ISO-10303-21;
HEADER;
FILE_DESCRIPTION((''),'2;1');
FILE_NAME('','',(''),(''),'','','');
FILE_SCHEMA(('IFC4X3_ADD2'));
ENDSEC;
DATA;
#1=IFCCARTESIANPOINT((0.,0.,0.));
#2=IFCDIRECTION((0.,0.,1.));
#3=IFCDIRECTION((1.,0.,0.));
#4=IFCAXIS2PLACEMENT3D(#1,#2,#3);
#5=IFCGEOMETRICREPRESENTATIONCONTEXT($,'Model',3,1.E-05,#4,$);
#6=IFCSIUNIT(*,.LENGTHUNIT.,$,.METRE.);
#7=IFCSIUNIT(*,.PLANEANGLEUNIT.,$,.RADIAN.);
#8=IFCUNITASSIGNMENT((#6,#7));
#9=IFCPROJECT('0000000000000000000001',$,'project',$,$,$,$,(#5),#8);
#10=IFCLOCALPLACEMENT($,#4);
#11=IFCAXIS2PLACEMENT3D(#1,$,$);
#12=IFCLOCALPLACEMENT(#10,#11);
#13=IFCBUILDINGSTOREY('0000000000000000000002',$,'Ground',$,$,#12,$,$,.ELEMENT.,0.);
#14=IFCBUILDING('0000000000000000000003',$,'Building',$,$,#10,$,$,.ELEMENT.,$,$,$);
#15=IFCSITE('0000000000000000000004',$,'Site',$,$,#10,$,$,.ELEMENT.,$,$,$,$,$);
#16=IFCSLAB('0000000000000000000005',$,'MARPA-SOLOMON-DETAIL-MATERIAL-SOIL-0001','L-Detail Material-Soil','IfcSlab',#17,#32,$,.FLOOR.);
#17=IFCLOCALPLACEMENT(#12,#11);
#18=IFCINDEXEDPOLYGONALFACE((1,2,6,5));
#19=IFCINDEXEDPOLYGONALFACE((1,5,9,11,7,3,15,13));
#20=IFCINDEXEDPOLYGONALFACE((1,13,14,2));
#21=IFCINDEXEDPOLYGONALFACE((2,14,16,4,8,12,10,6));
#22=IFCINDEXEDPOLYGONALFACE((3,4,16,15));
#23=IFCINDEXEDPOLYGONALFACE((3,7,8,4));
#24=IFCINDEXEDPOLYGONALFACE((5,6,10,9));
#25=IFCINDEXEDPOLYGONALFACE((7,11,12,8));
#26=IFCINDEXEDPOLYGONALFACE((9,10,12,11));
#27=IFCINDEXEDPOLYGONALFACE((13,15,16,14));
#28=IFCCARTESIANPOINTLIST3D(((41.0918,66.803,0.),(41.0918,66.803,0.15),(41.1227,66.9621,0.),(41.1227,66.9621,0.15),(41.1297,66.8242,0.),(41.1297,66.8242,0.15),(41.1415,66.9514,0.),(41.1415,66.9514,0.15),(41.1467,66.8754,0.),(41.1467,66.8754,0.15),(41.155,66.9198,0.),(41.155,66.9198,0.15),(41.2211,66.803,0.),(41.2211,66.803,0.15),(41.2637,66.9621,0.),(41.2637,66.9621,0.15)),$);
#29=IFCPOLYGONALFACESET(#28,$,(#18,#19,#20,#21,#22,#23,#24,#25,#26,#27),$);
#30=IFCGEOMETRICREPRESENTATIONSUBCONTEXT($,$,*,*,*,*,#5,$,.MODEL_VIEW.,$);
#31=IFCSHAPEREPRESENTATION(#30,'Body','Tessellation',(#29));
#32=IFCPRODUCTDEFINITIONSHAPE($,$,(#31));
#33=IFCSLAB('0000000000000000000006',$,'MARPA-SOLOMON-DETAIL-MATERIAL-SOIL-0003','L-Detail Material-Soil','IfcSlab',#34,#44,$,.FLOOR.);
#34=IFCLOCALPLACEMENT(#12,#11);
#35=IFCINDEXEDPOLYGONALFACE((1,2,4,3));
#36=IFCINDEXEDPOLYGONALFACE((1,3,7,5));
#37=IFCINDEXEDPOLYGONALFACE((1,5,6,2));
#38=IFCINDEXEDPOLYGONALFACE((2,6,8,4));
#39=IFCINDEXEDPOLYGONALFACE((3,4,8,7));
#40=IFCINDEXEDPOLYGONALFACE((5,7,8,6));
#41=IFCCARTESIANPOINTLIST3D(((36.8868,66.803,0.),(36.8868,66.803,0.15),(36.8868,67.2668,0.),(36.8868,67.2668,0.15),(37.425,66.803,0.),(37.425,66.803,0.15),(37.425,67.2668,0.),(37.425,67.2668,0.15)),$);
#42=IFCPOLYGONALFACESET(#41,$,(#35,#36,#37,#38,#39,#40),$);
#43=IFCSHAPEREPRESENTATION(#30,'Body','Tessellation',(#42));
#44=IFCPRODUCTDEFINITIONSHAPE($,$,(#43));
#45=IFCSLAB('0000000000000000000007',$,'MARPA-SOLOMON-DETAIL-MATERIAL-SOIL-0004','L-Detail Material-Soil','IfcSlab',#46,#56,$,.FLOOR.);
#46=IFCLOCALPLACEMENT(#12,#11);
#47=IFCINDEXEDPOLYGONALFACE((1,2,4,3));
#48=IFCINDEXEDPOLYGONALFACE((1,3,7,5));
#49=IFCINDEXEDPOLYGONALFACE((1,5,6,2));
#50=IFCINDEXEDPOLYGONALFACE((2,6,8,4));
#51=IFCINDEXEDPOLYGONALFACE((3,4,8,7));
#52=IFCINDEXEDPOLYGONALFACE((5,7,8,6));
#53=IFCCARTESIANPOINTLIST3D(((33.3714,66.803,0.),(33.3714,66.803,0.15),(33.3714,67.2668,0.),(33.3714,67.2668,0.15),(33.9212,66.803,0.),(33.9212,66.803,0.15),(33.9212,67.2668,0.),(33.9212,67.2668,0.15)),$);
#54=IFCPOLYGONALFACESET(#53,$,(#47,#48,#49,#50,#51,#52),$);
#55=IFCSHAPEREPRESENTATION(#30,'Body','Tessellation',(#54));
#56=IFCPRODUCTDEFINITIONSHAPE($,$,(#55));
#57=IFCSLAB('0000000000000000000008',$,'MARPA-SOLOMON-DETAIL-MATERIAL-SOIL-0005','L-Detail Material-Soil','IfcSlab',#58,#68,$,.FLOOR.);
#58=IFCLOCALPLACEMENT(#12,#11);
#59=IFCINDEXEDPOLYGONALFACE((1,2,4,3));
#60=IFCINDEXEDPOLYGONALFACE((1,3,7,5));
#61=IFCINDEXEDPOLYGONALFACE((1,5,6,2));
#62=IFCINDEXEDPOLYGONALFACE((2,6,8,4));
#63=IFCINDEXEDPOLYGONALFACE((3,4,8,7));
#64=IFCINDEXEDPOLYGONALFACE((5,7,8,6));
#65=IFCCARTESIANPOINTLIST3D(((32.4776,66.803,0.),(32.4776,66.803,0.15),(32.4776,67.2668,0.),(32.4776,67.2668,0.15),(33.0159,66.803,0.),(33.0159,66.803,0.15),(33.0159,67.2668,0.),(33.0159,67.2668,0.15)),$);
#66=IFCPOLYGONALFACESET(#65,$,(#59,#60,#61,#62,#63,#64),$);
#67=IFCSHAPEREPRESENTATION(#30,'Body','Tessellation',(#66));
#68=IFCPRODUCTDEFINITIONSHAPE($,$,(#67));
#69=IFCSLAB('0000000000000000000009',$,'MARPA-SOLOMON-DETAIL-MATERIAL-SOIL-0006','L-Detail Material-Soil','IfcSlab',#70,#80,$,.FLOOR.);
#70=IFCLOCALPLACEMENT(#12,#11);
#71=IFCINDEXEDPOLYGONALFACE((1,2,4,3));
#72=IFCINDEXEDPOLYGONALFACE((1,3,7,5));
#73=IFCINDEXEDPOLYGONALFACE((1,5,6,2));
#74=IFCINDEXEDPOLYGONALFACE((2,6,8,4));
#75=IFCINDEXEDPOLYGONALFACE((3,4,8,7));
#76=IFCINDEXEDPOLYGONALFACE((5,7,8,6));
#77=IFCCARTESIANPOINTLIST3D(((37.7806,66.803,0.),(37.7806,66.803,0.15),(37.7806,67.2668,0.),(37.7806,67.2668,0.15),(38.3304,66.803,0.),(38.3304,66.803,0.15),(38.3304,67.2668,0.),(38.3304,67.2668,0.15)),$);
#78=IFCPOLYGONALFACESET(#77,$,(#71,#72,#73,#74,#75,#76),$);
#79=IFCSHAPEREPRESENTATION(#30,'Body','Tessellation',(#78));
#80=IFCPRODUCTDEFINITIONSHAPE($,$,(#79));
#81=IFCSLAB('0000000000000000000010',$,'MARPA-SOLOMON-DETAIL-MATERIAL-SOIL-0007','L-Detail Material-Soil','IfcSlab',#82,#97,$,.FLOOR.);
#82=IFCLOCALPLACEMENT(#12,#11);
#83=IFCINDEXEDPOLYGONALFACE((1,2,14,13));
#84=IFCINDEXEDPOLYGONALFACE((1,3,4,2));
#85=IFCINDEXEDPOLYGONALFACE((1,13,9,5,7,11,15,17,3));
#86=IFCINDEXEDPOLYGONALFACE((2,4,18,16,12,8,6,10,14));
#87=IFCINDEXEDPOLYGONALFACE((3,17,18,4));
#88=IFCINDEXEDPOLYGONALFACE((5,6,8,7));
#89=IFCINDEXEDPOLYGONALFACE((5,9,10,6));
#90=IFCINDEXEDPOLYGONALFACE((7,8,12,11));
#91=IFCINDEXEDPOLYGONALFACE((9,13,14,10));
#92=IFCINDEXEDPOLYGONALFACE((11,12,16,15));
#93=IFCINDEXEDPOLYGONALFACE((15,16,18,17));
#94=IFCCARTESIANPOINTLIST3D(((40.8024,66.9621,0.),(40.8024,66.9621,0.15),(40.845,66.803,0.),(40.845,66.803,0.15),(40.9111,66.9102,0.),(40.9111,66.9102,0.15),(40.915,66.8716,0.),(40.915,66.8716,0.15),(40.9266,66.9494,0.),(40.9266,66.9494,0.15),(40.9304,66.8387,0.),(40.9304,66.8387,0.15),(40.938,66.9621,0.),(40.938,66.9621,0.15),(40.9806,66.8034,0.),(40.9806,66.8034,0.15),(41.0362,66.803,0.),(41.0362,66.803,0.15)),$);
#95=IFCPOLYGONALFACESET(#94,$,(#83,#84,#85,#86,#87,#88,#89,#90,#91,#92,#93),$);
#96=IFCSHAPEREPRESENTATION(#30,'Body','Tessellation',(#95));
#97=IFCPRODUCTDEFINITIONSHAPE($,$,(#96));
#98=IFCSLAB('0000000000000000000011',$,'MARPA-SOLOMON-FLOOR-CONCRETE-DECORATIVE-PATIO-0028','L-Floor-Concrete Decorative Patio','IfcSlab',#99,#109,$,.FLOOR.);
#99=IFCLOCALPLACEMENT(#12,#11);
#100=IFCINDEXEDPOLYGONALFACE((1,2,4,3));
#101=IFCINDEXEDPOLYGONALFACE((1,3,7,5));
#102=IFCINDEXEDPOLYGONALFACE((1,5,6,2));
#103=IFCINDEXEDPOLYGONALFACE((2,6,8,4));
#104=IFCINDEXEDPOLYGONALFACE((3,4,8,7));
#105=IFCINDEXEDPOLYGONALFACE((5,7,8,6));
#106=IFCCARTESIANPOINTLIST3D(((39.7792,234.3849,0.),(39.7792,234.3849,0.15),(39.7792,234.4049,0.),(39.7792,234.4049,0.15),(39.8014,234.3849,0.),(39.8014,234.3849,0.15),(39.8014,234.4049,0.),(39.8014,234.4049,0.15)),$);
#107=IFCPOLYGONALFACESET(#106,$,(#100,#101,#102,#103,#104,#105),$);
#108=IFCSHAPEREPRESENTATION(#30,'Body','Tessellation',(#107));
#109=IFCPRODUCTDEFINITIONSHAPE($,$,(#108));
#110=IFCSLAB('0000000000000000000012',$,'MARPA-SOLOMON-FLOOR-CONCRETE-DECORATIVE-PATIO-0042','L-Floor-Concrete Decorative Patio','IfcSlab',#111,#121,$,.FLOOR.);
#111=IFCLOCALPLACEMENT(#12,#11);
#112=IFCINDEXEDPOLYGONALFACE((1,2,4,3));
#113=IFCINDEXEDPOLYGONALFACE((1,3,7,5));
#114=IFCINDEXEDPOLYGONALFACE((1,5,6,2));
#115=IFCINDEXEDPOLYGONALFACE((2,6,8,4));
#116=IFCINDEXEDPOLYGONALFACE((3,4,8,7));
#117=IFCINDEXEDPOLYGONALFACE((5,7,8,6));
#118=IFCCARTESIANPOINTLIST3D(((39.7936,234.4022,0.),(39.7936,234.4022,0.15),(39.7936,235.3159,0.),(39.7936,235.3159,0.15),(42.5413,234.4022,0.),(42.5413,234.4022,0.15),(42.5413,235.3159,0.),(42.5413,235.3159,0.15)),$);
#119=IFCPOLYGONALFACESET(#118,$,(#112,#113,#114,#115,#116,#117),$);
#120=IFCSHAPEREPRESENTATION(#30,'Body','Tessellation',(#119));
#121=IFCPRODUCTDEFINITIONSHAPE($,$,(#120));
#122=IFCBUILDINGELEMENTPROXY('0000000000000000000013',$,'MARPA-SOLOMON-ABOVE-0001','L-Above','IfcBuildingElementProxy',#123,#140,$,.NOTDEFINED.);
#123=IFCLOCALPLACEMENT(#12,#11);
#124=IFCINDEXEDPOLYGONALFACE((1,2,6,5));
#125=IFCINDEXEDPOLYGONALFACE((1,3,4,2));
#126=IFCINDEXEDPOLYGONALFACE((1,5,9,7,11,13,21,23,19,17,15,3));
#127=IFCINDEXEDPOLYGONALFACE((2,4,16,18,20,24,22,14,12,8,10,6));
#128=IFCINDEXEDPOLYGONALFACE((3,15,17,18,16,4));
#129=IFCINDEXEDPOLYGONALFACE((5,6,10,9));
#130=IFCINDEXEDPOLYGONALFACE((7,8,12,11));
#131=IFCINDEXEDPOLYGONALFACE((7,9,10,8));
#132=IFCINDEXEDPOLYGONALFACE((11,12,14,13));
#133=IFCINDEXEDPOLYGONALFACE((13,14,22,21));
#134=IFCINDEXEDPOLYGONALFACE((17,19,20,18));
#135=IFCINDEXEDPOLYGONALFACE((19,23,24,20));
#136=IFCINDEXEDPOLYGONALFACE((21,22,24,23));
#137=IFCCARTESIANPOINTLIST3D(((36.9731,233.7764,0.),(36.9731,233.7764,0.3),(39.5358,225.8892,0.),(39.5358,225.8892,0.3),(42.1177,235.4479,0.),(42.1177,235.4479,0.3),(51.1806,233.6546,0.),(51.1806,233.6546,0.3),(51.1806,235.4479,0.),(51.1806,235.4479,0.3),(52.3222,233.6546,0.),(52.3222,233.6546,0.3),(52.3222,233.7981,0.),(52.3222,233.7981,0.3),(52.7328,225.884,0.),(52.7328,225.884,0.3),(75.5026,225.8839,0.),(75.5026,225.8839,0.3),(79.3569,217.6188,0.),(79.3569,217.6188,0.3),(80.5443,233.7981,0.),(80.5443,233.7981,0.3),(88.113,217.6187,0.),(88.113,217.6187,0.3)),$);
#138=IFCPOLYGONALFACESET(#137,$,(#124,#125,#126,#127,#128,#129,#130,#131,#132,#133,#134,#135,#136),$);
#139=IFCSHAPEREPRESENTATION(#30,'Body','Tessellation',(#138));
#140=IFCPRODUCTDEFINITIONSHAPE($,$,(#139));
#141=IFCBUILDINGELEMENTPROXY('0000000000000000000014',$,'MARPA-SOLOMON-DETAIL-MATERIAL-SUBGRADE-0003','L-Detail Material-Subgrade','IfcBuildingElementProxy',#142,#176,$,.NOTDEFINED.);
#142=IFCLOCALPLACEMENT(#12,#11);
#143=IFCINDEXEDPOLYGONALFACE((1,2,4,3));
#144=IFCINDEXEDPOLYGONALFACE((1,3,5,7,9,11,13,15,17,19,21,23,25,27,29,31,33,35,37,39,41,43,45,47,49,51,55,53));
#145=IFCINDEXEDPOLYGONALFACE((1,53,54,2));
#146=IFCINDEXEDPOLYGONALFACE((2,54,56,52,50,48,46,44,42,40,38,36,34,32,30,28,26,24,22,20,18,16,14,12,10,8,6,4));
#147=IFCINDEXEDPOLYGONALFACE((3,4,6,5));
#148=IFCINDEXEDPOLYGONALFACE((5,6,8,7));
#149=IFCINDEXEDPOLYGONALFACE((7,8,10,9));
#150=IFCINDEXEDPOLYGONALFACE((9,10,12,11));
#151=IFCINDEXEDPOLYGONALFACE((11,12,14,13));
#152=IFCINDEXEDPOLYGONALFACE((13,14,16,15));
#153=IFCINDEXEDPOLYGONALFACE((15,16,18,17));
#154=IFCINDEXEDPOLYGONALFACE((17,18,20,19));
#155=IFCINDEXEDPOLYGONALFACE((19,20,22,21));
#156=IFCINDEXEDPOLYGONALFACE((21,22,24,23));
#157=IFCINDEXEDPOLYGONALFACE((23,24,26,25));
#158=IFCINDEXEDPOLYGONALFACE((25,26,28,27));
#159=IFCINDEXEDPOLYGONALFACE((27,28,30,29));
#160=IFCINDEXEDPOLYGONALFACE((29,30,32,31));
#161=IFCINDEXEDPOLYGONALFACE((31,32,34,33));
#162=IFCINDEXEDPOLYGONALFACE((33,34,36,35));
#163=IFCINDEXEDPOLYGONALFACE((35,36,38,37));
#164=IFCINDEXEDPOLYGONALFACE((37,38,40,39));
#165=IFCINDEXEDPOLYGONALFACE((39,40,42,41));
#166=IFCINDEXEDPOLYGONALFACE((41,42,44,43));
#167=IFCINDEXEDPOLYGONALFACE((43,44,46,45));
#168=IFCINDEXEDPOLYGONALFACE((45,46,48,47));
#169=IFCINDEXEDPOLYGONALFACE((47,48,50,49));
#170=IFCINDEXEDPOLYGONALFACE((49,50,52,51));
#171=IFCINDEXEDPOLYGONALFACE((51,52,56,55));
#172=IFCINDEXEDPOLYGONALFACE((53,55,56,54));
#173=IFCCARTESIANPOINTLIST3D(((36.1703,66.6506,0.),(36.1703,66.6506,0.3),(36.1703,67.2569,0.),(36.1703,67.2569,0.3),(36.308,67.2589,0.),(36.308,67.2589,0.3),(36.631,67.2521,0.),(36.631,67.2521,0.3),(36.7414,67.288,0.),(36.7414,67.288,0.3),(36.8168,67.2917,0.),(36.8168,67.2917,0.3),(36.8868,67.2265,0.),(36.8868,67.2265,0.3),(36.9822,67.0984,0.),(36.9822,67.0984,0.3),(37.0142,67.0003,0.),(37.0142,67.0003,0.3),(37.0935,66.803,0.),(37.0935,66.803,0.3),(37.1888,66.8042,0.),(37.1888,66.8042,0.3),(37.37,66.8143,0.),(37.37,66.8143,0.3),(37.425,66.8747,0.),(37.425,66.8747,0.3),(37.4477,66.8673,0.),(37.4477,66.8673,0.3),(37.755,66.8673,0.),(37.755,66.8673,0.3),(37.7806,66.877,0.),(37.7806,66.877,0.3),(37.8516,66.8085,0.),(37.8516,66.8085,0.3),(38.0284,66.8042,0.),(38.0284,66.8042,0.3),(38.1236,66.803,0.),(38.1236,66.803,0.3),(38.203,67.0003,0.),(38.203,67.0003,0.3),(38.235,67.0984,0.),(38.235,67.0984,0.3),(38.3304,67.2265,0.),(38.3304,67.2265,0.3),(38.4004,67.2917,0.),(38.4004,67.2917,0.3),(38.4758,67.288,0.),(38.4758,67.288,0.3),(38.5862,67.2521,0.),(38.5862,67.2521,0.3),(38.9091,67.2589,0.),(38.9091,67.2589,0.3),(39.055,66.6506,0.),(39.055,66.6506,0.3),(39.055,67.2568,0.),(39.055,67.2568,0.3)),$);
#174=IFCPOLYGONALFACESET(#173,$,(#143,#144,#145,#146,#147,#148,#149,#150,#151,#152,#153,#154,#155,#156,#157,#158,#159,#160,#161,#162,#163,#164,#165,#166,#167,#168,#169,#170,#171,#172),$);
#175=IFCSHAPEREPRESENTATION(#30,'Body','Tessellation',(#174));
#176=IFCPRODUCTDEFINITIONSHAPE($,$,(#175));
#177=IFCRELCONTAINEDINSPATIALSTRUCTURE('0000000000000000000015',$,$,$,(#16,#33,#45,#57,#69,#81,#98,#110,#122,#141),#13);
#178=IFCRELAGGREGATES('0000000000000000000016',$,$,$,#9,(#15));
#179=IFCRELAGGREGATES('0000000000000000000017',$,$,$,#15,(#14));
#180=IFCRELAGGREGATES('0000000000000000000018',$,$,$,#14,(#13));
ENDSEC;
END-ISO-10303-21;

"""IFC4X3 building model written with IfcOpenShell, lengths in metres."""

from ifc_helpers import new_model, si_unit, frame, frame_2d, origin, origin_with_axes, place, context, subcontext, project, spatial, polyline, rectangle, outline, extrude, element, save


model = new_model("IFC4X3")

# Units and contexts
model_context = context("Model", 3, precision=1e-05, world=origin_with_axes())
sub_context = subcontext(model_context, None, None, "MODEL_VIEW")
ifc_project = project(units=[si_unit("LENGTHUNIT", "METRE"), si_unit("PLANEANGLEUNIT", "RADIAN")], contexts=[model_context])

# Site, building, storey
placement = place(None, origin_with_axes())
site = spatial("IfcSite", under=ifc_project, at=placement, Name="Site", CompositionType="ELEMENT")
building = spatial("IfcBuilding", under=site, at=placement, Name="Building", CompositionType="ELEMENT")
storey_placement = place(placement, origin())
storey = spatial("IfcBuildingStorey", under=building, at=storey_placement, Name="Ground", CompositionType="ELEMENT", Elevation=0.0)

# Slabs
slab_1_placement = place(storey_placement, frame((41.0918, 66.803, 0.0)))
element("IfcSlab", 1, at=slab_1_placement, inside=storey, Name="MARPA-SOLOMON-DETAIL-MATERIAL-SOIL-0001", Description="L-Detail Material-Soil", ObjectType="IfcSlab", PredefinedType="FLOOR", context=sub_context, shape_type="SweptSolid", body=[
    extrude(outline(polyline([(0.0309, 0.1591), (0.0497, 0.1483), (0.0632, 0.1168), (0.0548, 0.0724), (0.0379, 0.0211), (0.0, 0.0), (0.1292, 0.0), (0.1719, 0.1591), (0.0309, 0.1591)])), origin(), (0.0, 0.0, 1.0), 0.15),
])
slab_2_placement = place(storey_placement, frame((36.8868, 66.803, 0.0)))
element("IfcSlab", 2, at=slab_2_placement, inside=storey, Name="MARPA-SOLOMON-DETAIL-MATERIAL-SOIL-0003", Description="L-Detail Material-Soil", ObjectType="IfcSlab", PredefinedType="FLOOR", context=sub_context, shape_type="SweptSolid", body=[
    extrude(rectangle(XDim=0.5383, YDim=0.4638, at=frame_2d((0.2691, 0.2319))), origin(), (0.0, 0.0, 1.0), 0.15),
])
slab_3_placement = place(storey_placement, frame((33.3714, 66.803, 0.0)))
element("IfcSlab", 3, at=slab_3_placement, inside=storey, Name="MARPA-SOLOMON-DETAIL-MATERIAL-SOIL-0004", Description="L-Detail Material-Soil", ObjectType="IfcSlab", PredefinedType="FLOOR", context=sub_context, shape_type="SweptSolid", body=[
    extrude(rectangle(XDim=0.5498, YDim=0.4638, at=frame_2d((0.2749, 0.2319))), origin(), (0.0, 0.0, 1.0), 0.15),
])
slab_4_placement = place(storey_placement, frame((32.4776, 66.803, 0.0)))
element("IfcSlab", 4, at=slab_4_placement, inside=storey, Name="MARPA-SOLOMON-DETAIL-MATERIAL-SOIL-0005", Description="L-Detail Material-Soil", ObjectType="IfcSlab", PredefinedType="FLOOR", context=sub_context, shape_type="SweptSolid", body=[
    extrude(rectangle(XDim=0.5383, YDim=0.4638, at=frame_2d((0.2691, 0.2319))), origin(), (0.0, 0.0, 1.0), 0.15),
])
slab_5_placement = place(storey_placement, frame((37.7806, 66.803, 0.0)))
element("IfcSlab", 5, at=slab_5_placement, inside=storey, Name="MARPA-SOLOMON-DETAIL-MATERIAL-SOIL-0006", Description="L-Detail Material-Soil", ObjectType="IfcSlab", PredefinedType="FLOOR", context=sub_context, shape_type="SweptSolid", body=[
    extrude(rectangle(XDim=0.5498, YDim=0.4638, at=frame_2d((0.2749, 0.2319))), origin(), (0.0, 0.0, 1.0), 0.15),
])
slab_6_placement = place(storey_placement, frame((40.8024, 66.803, 0.0)))
element("IfcSlab", 6, at=slab_6_placement, inside=storey, Name="MARPA-SOLOMON-DETAIL-MATERIAL-SOIL-0007", Description="L-Detail Material-Soil", ObjectType="IfcSlab", PredefinedType="FLOOR", context=sub_context, shape_type="SweptSolid", body=[
    extrude(outline(polyline([(0.2337, 0.0), (0.1782, 0.0003), (0.128, 0.0357), (0.1126, 0.0685), (0.1087, 0.1071), (0.1241, 0.1464), (0.1356, 0.1591), (0.0, 0.1591), (0.0426, 0.0), (0.2337, 0.0)])), origin(), (0.0, 0.0, 1.0), 0.15),
])
slab_7_placement = place(storey_placement, frame((39.7792, 234.3849, 0.0)))
element("IfcSlab", 7, at=slab_7_placement, inside=storey, Name="MARPA-SOLOMON-FLOOR-CONCRETE-DECORATIVE-PATIO-0028", Description="L-Floor-Concrete Decorative Patio", ObjectType="IfcSlab", PredefinedType="FLOOR", context=sub_context, shape_type="SweptSolid", body=[
    extrude(rectangle(XDim=0.0222, YDim=0.02, at=frame_2d((0.0111, 0.01))), origin(), (0.0, 0.0, 1.0), 0.15),
])
slab_8_placement = place(storey_placement, frame((39.7936, 234.4022, 0.0)))
element("IfcSlab", 8, at=slab_8_placement, inside=storey, Name="MARPA-SOLOMON-FLOOR-CONCRETE-DECORATIVE-PATIO-0042", Description="L-Floor-Concrete Decorative Patio", ObjectType="IfcSlab", PredefinedType="FLOOR", context=sub_context, shape_type="SweptSolid", body=[
    extrude(rectangle(XDim=2.7478, YDim=0.9138, at=frame_2d((1.3739, 0.4569))), origin(), (0.0, 0.0, 1.0), 0.15),
])

# Building element proxies
proxy_1_placement = place(placement, frame((36.9731, 217.6187, 0.0)))
element("IfcBuildingElementProxy", 9, at=proxy_1_placement, inside=storey, Name="MARPA-SOLOMON-ABOVE-0001", Description="L-Above", ObjectType="IfcBuildingElementProxy", PredefinedType="NOTDEFINED", context=sub_context, shape_type="SweptSolid", body=[
    extrude(outline(polyline([(5.1446, 17.8292), (14.2075, 17.8292), (14.2075, 16.0359), (15.3492, 16.0359), (15.3492, 16.1793), (43.5712, 16.1793), (51.14, 0.0), (42.3838, 0.0), (38.5295, 8.2652), (15.7597, 8.2652), (2.5627, 8.2704), (0.0, 16.1576), (5.1446, 17.8292)])), origin(), (0.0, 0.0, 1.0), 0.3),
])
proxy_2_placement = place(placement, frame((36.1703, 66.6506, 0.0)))
element("IfcBuildingElementProxy", 10, at=proxy_2_placement, inside=storey, Name="MARPA-SOLOMON-DETAIL-MATERIAL-SUBGRADE-0003", Description="L-Detail Material-Subgrade", ObjectType="IfcBuildingElementProxy", PredefinedType="NOTDEFINED", context=sub_context, shape_type="SweptSolid", body=[
    extrude(outline(polyline([(0.0, 0.0), (2.8847, 0.0), (2.8847, 0.6062), (2.7389, 0.6083), (2.4159, 0.6015), (2.3055, 0.6373), (2.2301, 0.641), (2.1601, 0.5759), (2.0647, 0.4478), (2.0327, 0.3497), (1.9534, 0.1524), (1.8581, 0.1536), (1.6814, 0.1579), (1.6103, 0.2263), (1.5847, 0.2167), (1.2774, 0.2167), (1.2548, 0.2241), (1.1997, 0.1637), (1.0185, 0.1536), (0.9233, 0.1524), (0.8439, 0.3497), (0.8119, 0.4478), (0.7165, 0.5759), (0.6465, 0.641), (0.5711, 0.6373), (0.4607, 0.6015), (0.1378, 0.6083), (0.0, 0.6063), (0.0, 0.0)])), origin(), (0.0, 0.0, 1.0), 0.3),
])

save(model, "model.ifc")
